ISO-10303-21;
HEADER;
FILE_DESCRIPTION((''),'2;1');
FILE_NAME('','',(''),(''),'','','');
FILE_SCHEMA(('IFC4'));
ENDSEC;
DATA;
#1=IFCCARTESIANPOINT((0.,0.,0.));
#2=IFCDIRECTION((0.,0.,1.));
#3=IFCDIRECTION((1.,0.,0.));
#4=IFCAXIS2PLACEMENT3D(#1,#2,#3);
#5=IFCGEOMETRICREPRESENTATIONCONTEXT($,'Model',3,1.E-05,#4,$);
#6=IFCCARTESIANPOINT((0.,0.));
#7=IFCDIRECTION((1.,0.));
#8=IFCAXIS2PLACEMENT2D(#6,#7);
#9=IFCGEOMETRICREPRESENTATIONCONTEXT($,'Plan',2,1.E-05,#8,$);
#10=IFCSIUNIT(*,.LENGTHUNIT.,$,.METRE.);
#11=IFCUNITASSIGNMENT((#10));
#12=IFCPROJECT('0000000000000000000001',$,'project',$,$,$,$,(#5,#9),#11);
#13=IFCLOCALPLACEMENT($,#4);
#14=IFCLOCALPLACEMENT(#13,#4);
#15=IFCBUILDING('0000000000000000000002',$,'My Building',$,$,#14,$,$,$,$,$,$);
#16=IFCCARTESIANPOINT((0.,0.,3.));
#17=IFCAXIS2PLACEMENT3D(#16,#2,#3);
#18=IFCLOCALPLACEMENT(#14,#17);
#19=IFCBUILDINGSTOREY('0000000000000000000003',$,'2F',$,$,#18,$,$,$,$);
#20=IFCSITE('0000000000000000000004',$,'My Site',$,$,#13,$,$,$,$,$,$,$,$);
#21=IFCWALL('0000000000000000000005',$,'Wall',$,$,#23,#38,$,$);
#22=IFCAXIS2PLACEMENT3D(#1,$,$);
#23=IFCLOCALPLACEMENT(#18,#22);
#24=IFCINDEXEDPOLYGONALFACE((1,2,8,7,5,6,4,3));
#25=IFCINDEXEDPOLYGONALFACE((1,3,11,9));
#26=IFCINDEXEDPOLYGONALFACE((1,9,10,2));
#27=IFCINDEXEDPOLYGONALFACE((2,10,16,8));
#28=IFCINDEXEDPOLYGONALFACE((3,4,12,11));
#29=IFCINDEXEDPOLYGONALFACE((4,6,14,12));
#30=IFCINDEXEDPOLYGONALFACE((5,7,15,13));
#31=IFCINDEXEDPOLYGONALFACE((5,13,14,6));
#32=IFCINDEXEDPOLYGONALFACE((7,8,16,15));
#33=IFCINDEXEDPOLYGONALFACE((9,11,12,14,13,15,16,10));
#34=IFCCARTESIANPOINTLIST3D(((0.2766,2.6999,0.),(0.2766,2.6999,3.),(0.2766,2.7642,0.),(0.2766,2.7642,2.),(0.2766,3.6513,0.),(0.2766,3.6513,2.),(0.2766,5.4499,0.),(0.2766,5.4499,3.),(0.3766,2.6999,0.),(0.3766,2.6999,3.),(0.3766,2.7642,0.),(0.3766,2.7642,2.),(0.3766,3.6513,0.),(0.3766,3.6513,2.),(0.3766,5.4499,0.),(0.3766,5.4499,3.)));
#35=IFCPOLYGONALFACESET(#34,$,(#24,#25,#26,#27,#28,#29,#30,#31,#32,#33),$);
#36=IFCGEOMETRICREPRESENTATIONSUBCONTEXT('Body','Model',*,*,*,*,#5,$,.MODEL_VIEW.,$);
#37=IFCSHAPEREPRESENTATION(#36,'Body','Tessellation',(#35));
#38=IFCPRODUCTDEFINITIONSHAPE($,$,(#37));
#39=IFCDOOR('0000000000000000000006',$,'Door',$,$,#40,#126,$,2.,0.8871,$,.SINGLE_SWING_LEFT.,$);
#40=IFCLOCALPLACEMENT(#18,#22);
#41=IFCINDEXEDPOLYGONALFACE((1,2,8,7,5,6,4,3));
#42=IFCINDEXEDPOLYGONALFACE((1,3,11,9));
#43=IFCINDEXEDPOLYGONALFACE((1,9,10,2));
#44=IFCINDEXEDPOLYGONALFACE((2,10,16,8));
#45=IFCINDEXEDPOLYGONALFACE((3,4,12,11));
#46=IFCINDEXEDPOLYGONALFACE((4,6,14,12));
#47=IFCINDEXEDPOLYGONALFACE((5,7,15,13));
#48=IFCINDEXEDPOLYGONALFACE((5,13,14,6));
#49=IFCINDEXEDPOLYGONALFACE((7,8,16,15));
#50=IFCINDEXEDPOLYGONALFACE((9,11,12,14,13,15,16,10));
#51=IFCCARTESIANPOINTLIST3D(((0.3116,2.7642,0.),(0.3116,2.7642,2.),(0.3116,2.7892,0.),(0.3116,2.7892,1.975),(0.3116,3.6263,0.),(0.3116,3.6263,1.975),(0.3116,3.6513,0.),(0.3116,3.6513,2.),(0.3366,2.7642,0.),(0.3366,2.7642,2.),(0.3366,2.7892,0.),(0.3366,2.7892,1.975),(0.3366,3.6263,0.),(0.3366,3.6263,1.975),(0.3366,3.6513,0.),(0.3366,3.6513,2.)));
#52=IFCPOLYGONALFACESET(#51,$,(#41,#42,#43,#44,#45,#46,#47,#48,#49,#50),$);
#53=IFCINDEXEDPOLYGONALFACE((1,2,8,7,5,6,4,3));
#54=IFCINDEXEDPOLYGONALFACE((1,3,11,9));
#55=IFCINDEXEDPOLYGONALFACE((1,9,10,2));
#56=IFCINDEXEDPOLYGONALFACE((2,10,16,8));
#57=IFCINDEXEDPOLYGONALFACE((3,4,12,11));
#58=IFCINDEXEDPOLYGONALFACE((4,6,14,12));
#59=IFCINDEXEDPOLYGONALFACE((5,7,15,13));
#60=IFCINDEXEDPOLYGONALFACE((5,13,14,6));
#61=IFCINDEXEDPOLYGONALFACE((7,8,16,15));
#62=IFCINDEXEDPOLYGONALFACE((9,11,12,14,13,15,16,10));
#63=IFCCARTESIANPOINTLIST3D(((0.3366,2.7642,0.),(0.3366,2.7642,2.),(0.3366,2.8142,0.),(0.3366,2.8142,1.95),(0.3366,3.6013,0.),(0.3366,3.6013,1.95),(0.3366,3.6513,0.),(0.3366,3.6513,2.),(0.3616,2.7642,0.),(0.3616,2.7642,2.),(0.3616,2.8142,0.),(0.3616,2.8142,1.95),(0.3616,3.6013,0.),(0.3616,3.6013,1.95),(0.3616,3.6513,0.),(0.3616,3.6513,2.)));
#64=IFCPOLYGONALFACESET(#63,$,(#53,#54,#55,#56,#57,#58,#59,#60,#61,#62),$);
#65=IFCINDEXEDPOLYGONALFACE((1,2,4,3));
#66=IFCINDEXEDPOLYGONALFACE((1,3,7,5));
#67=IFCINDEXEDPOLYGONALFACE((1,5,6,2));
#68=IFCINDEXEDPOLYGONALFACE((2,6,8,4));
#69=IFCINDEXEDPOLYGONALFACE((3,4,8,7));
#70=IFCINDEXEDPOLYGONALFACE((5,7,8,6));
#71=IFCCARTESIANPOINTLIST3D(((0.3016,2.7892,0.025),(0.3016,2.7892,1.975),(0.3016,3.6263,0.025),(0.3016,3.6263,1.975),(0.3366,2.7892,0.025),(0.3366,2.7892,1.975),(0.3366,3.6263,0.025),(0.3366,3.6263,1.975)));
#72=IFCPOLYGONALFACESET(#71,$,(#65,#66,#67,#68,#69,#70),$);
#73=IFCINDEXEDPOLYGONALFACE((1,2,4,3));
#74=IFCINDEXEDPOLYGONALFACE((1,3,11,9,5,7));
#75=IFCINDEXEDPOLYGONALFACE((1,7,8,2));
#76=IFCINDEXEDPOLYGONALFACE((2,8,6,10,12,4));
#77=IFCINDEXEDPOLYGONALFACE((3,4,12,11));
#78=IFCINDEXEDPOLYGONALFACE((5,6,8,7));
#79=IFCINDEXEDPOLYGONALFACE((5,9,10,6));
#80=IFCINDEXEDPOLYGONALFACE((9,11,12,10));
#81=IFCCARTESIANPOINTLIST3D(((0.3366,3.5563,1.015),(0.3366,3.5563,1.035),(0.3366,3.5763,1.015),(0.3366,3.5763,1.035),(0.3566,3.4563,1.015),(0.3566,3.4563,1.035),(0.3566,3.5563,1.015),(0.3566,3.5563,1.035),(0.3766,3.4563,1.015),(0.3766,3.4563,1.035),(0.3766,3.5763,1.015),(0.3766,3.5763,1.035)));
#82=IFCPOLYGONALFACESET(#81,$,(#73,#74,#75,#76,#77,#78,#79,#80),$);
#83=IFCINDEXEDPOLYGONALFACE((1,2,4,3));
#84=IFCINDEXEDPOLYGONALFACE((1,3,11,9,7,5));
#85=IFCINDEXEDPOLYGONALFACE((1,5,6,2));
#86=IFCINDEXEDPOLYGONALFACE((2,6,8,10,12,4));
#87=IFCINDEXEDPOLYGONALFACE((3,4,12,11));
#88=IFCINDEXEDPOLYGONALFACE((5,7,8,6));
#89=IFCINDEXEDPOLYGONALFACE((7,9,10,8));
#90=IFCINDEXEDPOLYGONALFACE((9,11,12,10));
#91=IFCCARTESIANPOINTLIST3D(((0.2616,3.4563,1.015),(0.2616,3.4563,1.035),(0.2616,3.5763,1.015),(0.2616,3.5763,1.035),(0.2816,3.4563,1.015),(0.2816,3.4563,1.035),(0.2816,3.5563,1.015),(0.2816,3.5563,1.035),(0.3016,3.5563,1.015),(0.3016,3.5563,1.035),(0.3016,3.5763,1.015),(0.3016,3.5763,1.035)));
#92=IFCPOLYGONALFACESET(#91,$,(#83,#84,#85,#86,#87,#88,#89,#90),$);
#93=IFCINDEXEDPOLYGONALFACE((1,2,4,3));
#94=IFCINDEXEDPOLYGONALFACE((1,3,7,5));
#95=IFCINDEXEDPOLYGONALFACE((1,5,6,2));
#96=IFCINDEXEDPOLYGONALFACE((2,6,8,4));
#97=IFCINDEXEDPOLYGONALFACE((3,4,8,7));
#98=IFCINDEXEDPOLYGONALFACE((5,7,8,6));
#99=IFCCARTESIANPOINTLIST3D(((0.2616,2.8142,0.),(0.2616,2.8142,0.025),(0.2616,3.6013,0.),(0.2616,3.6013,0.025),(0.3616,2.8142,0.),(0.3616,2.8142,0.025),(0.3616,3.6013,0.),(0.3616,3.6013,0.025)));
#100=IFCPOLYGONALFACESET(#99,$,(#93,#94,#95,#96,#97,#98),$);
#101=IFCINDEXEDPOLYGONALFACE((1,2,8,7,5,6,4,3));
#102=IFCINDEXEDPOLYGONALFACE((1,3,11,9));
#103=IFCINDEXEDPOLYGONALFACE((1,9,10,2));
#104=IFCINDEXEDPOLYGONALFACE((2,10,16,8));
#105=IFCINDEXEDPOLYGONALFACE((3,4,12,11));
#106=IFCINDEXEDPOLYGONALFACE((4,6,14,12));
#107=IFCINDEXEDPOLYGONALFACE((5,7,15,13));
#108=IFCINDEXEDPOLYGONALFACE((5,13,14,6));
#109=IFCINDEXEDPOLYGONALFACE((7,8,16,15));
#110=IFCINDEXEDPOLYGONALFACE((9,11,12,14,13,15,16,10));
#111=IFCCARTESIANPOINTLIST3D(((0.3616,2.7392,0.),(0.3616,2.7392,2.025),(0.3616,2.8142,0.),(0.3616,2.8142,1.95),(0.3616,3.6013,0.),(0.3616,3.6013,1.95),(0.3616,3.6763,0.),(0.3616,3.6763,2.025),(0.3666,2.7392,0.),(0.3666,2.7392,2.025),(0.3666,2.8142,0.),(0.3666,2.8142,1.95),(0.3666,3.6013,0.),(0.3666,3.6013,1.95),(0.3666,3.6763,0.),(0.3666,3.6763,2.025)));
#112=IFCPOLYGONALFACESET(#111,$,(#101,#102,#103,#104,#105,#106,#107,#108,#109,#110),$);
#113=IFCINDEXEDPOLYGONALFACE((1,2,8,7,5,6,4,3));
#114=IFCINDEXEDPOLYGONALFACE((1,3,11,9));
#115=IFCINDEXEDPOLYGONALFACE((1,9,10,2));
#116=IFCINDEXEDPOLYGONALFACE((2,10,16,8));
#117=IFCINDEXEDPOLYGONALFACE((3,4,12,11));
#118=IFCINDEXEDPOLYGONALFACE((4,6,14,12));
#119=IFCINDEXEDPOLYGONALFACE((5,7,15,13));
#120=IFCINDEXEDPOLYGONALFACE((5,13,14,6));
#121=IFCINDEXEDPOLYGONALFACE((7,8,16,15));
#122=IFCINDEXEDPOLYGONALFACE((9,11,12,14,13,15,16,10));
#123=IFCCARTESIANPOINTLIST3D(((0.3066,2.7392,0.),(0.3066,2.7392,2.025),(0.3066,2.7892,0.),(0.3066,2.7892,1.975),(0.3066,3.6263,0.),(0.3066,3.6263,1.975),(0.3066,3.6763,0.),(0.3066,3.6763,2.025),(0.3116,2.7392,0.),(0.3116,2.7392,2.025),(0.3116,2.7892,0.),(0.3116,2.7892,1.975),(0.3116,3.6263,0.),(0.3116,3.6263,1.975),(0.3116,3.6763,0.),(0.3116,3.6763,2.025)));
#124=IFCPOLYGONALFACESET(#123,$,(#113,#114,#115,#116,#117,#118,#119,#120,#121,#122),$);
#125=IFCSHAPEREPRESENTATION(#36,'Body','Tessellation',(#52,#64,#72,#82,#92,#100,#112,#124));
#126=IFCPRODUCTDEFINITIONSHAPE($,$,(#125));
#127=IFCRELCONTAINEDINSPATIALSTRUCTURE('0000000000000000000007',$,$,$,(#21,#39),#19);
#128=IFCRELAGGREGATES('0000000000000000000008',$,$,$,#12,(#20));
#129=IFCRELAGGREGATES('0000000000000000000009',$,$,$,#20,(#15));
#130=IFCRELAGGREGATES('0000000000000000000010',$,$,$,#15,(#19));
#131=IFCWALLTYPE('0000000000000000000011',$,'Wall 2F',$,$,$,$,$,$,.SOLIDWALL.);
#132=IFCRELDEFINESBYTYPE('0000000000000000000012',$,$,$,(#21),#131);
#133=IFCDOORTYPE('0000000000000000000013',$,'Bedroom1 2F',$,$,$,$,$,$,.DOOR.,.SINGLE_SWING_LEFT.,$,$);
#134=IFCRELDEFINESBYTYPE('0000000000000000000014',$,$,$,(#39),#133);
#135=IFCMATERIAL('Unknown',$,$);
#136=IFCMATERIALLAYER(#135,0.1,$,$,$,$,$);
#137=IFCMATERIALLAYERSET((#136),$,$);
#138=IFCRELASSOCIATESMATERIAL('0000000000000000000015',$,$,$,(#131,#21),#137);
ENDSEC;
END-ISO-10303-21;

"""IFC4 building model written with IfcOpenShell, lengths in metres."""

from ifc_helpers import new_model, entity, si_unit, frame, origin_with_axes, origin_2d_with_axis, place, context, subcontext, project, spatial, line, indexed_curve, outline, extrude, shape, source, transform, mapped, material, layer, layer_set, layer_usage, type_object, type_shapes, element, fill, save


model = new_model("IFC4")

# Units and contexts
model_context = context("Model", 3, precision=1e-05, world=origin_with_axes())
plan_context = context("Plan", 2, precision=1e-05, world=origin_2d_with_axis())
body_context_1 = subcontext(model_context, "Body", "Model", "MODEL_VIEW")
body_context_2 = subcontext(plan_context, "Body", "Plan", "PLAN_VIEW")
ifc_project = project(units=[si_unit("LENGTHUNIT", "METRE")], contexts=[model_context, plan_context])

# Site, building, storey
site_placement = place(None, origin_with_axes())
site = spatial("IfcSite", under=ifc_project, at=site_placement, Name="My Site")
building_placement = place(site_placement, origin_with_axes())
building = spatial("IfcBuilding", under=site, at=building_placement, Name="My Building")
storey_placement = place(building_placement, frame((0.0, 0.0, 3.0), z_axis=(0.0, 0.0, 1.0), x_axis=(1.0, 0.0, 0.0)))
storey = spatial("IfcBuildingStorey", under=building, at=storey_placement, Name="2F")

# Shared definitions
ifc_material = material(Name="Unknown")
ifc_layer_1 = layer(ifc_material, 0.1)
ifc_layer_set_1 = layer_set([ifc_layer_1])
wall_type_1 = type_object("IfcWallType", Name="Wall 2F", PredefinedType="SOLIDWALL", material=ifc_layer_set_1)

# Wall, opening, door
ifc_layer_usage_1 = layer_usage(ifc_layer_set_1, "AXIS2", "POSITIVE", 0.0)
wall_1_placement = place(storey_placement, frame((0.3766, 2.6999, 0.0), z_axis=(0.0, 0.0, 1.0), x_axis=(0.0, 1.0, 0.0)))
wall_1 = element("IfcWall", 1, at=wall_1_placement, inside=storey, type_object=wall_type_1, material=ifc_layer_usage_1, Name="Wall", context=body_context_1, shape_type="SweptSolid", body=[
    extrude(outline(indexed_curve([(0.0, 0.0), (0.0, 0.1), (2.75, 0.1), (2.75, 0.0)], segments=[line(1, 2, 3, 4, 1)])), origin_with_axes(), (0.0, 0.0, 1.0), 3.0),
])
shared_shape_1 = source(origin_with_axes(), body_context_1, "Body", "SweptSolid", [
    extrude(outline(indexed_curve([(0.0, 0.0), (0.8871, 0.0), (0.8871, 2.0), (0.0, 2.0)], segments=[line(1, 2, 3, 4, 1)])), frame((0.0, -0.6, 0.0), z_axis=(0.0, -1.0, 0.0), x_axis=(1.0, 0.0, 0.0)), (0.0, 0.0, -1.0), 1.2),
])
opening_1_placement = place(wall_1_placement, frame((0.0644, 0.015, 0.0), z_axis=(0.0, 0.0, 1.0), x_axis=(1.0, 0.0, 0.0)))
opening_1 = element("IfcOpeningElement", 2, at=opening_1_placement, cuts=wall_1, PredefinedType="OPENING", context=body_context_1, shape_type="MappedRepresentation", body=[
    mapped(shared_shape_1, transform((0.0, 0.0, 0.0), x_axis=(1.0, 0.0, 0.0), y_axis=(0.0, 1.0, 0.0), z_axis=(0.0, 0.0, 1.0), scale=1.0)),
])
door_type_1 = type_object("IfcDoorType", Name="Bedroom1 2F", OperationType="SINGLE_SWING_LEFT", PredefinedType="DOOR")
shared_shape_2 = source(origin_with_axes(), body_context_1, "Body", "SweptSolid", [
    extrude(outline(indexed_curve([(0.0, 0.0), (0.0, 2.0), (0.8871, 2.0), (0.8871, 0.0), (0.8621, 0.0), (0.8621, 1.975), (0.025, 1.975), (0.025, 0.0)], segments=[line(1, 2, 3, 4, 5, 6, 7, 8, 1)])), frame((0.0, 0.025, 0.0), z_axis=(0.0, -1.0, 0.0), x_axis=(1.0, 0.0, 0.0)), (0.0, 0.0, -1.0), 0.025),
    extrude(outline(indexed_curve([(0.0, 0.0), (0.0, 2.0), (0.8871, 2.0), (0.8871, 0.0), (0.8371, 0.0), (0.8371, 1.95), (0.05, 1.95), (0.05, 0.0)], segments=[line(1, 2, 3, 4, 5, 6, 7, 8, 1)])), frame((0.0, 0.0, 0.0), z_axis=(0.0, -1.0, 0.0), x_axis=(1.0, 0.0, 0.0)), (0.0, 0.0, -1.0), 0.025),
    extrude(outline(indexed_curve([(0.0, 0.0), (0.8371, 0.0), (0.8371, 0.035), (0.0, 0.035)], segments=[line(1, 2, 3, 4, 1)])), frame((0.025, 0.025, 0.025), z_axis=(0.0, 0.0, 1.0), x_axis=(1.0, 0.0, 0.0)), (0.0, 0.0, 1.0), 1.95),
    extrude(outline(indexed_curve([(0.0, 0.0), (0.0, -0.04), (-0.12, -0.04), (-0.12, -0.02), (-0.02, -0.02), (-0.02, 0.0)], segments=[line(1, 2, 3, 4, 5, 6, 1)])), frame((0.8121, 0.025, 1.015), z_axis=(0.0, 0.0, 1.0), x_axis=(1.0, 0.0, 0.0)), (0.0, 0.0, 1.0), 0.02),
    extrude(outline(indexed_curve([(0.0, 0.0), (0.0, 0.04), (-0.12, 0.04), (-0.12, 0.02), (-0.02, 0.02), (-0.02, 0.0)], segments=[line(1, 2, 3, 4, 5, 6, 1)])), frame((0.8121, 0.06, 1.015), z_axis=(0.0, 0.0, 1.0), x_axis=(1.0, 0.0, 0.0)), (0.0, 0.0, 1.0), 0.02),
    extrude(outline(indexed_curve([(0.0, 0.0), (0.7871, 0.0), (0.7871, 0.1), (0.0, 0.1)], segments=[line(1, 2, 3, 4, 1)])), frame((0.05, 0.0, 0.0), z_axis=(0.0, 0.0, 1.0), x_axis=(1.0, 0.0, 0.0)), (0.0, 0.0, 1.0), 0.025),
    extrude(outline(indexed_curve([(0.0, 0.0), (0.0, 2.025), (0.9371, 2.025), (0.9371, 0.0), (0.8621, 0.0), (0.8621, 1.95), (0.075, 1.95), (0.075, 0.0)], segments=[line(1, 2, 3, 4, 5, 6, 7, 8, 1)])), frame((-0.025, -0.005, 0.0), z_axis=(0.0, -1.0, 0.0), x_axis=(1.0, 0.0, 0.0)), (0.0, 0.0, -1.0), 0.005),
    extrude(outline(indexed_curve([(0.0, 0.0), (0.0, 2.025), (0.9371, 2.025), (0.9371, 0.0), (0.8871, 0.0), (0.8871, 1.975), (0.05, 1.975), (0.05, 0.0)], segments=[line(1, 2, 3, 4, 5, 6, 7, 8, 1)])), frame((-0.025, 0.05, 0.0), z_axis=(0.0, -1.0, 0.0), x_axis=(1.0, 0.0, 0.0)), (0.0, 0.0, -1.0), 0.005),
])
shared_shape_3 = source(origin_with_axes(), body_context_2, "Body", "Curve2D", [
    entity("IfcIndexedPolyCurve", entity("IfcCartesianPointList2D", [[0.0, 0.0], [0.0, 0.05], [0.025, 0.05], [0.025, 0.025], [0.05, 0.025], [0.05, 0.0]]), [entity("IfcLineIndex", [1, 2, 3, 4, 5, 6, 1])]),
    entity("IfcIndexedPolyCurve", entity("IfcCartesianPointList2D", [[0.8871, 0.0], [0.8871, 0.05], [0.8621, 0.05], [0.8621, 0.025], [0.8371, 0.025], [0.8371, 0.0]]), [entity("IfcLineIndex", [1, 2, 3, 4, 5, 6, 1])]),
    entity("IfcTrimmedCurve", entity("IfcEllipse", entity("IfcAxis2Placement2D", entity("IfcCartesianPoint", [0.06, 0.05]), entity("IfcDirection", [1.0, 0.0])), 0.8021, 0.8371), [entity("IfcCartesianPoint", [0.8621, 0.05])], [entity("IfcCartesianPoint", [0.06, 0.8871])], True, "CARTESIAN"),
    entity("IfcIndexedPolyCurve", entity("IfcCartesianPointList2D", [[0.025, 0.05], [0.06, 0.05], [0.06, 0.8871], [0.025, 0.8871]]), [entity("IfcLineIndex", [1, 2, 3, 4, 1])]),
])
type_shapes(door_type_1, [shared_shape_2, shared_shape_3])
door_1_placement = place(opening_1_placement, frame((0.0, 0.0, 0.0), z_axis=(0.0, 0.0, 1.0), x_axis=(1.0, 0.0, 0.0)))
door_1 = element("IfcDoor", 3, at=door_1_placement, inside=storey, type_object=door_type_1, Name="Door", OperationType="SINGLE_SWING_LEFT", OverallHeight=2.0, OverallWidth=0.8871, shapes=[
    shape(body_context_1, "Body", "MappedRepresentation", [mapped(shared_shape_2, transform((0.0, 0.0, 0.0), x_axis=(1.0, 0.0, 0.0), y_axis=(0.0, 1.0, 0.0), z_axis=(0.0, 0.0, 1.0), scale=1.0))]),
    shape(body_context_2, "Body", "MappedRepresentation", [mapped(shared_shape_3, transform((0.0, 0.0, 0.0), x_axis=(1.0, 0.0, 0.0), y_axis=(0.0, 1.0, 0.0), z_axis=(0.0, 0.0, 1.0), scale=1.0))]),
])
fill(opening_1, door_1)

save(model, "model.ifc")
